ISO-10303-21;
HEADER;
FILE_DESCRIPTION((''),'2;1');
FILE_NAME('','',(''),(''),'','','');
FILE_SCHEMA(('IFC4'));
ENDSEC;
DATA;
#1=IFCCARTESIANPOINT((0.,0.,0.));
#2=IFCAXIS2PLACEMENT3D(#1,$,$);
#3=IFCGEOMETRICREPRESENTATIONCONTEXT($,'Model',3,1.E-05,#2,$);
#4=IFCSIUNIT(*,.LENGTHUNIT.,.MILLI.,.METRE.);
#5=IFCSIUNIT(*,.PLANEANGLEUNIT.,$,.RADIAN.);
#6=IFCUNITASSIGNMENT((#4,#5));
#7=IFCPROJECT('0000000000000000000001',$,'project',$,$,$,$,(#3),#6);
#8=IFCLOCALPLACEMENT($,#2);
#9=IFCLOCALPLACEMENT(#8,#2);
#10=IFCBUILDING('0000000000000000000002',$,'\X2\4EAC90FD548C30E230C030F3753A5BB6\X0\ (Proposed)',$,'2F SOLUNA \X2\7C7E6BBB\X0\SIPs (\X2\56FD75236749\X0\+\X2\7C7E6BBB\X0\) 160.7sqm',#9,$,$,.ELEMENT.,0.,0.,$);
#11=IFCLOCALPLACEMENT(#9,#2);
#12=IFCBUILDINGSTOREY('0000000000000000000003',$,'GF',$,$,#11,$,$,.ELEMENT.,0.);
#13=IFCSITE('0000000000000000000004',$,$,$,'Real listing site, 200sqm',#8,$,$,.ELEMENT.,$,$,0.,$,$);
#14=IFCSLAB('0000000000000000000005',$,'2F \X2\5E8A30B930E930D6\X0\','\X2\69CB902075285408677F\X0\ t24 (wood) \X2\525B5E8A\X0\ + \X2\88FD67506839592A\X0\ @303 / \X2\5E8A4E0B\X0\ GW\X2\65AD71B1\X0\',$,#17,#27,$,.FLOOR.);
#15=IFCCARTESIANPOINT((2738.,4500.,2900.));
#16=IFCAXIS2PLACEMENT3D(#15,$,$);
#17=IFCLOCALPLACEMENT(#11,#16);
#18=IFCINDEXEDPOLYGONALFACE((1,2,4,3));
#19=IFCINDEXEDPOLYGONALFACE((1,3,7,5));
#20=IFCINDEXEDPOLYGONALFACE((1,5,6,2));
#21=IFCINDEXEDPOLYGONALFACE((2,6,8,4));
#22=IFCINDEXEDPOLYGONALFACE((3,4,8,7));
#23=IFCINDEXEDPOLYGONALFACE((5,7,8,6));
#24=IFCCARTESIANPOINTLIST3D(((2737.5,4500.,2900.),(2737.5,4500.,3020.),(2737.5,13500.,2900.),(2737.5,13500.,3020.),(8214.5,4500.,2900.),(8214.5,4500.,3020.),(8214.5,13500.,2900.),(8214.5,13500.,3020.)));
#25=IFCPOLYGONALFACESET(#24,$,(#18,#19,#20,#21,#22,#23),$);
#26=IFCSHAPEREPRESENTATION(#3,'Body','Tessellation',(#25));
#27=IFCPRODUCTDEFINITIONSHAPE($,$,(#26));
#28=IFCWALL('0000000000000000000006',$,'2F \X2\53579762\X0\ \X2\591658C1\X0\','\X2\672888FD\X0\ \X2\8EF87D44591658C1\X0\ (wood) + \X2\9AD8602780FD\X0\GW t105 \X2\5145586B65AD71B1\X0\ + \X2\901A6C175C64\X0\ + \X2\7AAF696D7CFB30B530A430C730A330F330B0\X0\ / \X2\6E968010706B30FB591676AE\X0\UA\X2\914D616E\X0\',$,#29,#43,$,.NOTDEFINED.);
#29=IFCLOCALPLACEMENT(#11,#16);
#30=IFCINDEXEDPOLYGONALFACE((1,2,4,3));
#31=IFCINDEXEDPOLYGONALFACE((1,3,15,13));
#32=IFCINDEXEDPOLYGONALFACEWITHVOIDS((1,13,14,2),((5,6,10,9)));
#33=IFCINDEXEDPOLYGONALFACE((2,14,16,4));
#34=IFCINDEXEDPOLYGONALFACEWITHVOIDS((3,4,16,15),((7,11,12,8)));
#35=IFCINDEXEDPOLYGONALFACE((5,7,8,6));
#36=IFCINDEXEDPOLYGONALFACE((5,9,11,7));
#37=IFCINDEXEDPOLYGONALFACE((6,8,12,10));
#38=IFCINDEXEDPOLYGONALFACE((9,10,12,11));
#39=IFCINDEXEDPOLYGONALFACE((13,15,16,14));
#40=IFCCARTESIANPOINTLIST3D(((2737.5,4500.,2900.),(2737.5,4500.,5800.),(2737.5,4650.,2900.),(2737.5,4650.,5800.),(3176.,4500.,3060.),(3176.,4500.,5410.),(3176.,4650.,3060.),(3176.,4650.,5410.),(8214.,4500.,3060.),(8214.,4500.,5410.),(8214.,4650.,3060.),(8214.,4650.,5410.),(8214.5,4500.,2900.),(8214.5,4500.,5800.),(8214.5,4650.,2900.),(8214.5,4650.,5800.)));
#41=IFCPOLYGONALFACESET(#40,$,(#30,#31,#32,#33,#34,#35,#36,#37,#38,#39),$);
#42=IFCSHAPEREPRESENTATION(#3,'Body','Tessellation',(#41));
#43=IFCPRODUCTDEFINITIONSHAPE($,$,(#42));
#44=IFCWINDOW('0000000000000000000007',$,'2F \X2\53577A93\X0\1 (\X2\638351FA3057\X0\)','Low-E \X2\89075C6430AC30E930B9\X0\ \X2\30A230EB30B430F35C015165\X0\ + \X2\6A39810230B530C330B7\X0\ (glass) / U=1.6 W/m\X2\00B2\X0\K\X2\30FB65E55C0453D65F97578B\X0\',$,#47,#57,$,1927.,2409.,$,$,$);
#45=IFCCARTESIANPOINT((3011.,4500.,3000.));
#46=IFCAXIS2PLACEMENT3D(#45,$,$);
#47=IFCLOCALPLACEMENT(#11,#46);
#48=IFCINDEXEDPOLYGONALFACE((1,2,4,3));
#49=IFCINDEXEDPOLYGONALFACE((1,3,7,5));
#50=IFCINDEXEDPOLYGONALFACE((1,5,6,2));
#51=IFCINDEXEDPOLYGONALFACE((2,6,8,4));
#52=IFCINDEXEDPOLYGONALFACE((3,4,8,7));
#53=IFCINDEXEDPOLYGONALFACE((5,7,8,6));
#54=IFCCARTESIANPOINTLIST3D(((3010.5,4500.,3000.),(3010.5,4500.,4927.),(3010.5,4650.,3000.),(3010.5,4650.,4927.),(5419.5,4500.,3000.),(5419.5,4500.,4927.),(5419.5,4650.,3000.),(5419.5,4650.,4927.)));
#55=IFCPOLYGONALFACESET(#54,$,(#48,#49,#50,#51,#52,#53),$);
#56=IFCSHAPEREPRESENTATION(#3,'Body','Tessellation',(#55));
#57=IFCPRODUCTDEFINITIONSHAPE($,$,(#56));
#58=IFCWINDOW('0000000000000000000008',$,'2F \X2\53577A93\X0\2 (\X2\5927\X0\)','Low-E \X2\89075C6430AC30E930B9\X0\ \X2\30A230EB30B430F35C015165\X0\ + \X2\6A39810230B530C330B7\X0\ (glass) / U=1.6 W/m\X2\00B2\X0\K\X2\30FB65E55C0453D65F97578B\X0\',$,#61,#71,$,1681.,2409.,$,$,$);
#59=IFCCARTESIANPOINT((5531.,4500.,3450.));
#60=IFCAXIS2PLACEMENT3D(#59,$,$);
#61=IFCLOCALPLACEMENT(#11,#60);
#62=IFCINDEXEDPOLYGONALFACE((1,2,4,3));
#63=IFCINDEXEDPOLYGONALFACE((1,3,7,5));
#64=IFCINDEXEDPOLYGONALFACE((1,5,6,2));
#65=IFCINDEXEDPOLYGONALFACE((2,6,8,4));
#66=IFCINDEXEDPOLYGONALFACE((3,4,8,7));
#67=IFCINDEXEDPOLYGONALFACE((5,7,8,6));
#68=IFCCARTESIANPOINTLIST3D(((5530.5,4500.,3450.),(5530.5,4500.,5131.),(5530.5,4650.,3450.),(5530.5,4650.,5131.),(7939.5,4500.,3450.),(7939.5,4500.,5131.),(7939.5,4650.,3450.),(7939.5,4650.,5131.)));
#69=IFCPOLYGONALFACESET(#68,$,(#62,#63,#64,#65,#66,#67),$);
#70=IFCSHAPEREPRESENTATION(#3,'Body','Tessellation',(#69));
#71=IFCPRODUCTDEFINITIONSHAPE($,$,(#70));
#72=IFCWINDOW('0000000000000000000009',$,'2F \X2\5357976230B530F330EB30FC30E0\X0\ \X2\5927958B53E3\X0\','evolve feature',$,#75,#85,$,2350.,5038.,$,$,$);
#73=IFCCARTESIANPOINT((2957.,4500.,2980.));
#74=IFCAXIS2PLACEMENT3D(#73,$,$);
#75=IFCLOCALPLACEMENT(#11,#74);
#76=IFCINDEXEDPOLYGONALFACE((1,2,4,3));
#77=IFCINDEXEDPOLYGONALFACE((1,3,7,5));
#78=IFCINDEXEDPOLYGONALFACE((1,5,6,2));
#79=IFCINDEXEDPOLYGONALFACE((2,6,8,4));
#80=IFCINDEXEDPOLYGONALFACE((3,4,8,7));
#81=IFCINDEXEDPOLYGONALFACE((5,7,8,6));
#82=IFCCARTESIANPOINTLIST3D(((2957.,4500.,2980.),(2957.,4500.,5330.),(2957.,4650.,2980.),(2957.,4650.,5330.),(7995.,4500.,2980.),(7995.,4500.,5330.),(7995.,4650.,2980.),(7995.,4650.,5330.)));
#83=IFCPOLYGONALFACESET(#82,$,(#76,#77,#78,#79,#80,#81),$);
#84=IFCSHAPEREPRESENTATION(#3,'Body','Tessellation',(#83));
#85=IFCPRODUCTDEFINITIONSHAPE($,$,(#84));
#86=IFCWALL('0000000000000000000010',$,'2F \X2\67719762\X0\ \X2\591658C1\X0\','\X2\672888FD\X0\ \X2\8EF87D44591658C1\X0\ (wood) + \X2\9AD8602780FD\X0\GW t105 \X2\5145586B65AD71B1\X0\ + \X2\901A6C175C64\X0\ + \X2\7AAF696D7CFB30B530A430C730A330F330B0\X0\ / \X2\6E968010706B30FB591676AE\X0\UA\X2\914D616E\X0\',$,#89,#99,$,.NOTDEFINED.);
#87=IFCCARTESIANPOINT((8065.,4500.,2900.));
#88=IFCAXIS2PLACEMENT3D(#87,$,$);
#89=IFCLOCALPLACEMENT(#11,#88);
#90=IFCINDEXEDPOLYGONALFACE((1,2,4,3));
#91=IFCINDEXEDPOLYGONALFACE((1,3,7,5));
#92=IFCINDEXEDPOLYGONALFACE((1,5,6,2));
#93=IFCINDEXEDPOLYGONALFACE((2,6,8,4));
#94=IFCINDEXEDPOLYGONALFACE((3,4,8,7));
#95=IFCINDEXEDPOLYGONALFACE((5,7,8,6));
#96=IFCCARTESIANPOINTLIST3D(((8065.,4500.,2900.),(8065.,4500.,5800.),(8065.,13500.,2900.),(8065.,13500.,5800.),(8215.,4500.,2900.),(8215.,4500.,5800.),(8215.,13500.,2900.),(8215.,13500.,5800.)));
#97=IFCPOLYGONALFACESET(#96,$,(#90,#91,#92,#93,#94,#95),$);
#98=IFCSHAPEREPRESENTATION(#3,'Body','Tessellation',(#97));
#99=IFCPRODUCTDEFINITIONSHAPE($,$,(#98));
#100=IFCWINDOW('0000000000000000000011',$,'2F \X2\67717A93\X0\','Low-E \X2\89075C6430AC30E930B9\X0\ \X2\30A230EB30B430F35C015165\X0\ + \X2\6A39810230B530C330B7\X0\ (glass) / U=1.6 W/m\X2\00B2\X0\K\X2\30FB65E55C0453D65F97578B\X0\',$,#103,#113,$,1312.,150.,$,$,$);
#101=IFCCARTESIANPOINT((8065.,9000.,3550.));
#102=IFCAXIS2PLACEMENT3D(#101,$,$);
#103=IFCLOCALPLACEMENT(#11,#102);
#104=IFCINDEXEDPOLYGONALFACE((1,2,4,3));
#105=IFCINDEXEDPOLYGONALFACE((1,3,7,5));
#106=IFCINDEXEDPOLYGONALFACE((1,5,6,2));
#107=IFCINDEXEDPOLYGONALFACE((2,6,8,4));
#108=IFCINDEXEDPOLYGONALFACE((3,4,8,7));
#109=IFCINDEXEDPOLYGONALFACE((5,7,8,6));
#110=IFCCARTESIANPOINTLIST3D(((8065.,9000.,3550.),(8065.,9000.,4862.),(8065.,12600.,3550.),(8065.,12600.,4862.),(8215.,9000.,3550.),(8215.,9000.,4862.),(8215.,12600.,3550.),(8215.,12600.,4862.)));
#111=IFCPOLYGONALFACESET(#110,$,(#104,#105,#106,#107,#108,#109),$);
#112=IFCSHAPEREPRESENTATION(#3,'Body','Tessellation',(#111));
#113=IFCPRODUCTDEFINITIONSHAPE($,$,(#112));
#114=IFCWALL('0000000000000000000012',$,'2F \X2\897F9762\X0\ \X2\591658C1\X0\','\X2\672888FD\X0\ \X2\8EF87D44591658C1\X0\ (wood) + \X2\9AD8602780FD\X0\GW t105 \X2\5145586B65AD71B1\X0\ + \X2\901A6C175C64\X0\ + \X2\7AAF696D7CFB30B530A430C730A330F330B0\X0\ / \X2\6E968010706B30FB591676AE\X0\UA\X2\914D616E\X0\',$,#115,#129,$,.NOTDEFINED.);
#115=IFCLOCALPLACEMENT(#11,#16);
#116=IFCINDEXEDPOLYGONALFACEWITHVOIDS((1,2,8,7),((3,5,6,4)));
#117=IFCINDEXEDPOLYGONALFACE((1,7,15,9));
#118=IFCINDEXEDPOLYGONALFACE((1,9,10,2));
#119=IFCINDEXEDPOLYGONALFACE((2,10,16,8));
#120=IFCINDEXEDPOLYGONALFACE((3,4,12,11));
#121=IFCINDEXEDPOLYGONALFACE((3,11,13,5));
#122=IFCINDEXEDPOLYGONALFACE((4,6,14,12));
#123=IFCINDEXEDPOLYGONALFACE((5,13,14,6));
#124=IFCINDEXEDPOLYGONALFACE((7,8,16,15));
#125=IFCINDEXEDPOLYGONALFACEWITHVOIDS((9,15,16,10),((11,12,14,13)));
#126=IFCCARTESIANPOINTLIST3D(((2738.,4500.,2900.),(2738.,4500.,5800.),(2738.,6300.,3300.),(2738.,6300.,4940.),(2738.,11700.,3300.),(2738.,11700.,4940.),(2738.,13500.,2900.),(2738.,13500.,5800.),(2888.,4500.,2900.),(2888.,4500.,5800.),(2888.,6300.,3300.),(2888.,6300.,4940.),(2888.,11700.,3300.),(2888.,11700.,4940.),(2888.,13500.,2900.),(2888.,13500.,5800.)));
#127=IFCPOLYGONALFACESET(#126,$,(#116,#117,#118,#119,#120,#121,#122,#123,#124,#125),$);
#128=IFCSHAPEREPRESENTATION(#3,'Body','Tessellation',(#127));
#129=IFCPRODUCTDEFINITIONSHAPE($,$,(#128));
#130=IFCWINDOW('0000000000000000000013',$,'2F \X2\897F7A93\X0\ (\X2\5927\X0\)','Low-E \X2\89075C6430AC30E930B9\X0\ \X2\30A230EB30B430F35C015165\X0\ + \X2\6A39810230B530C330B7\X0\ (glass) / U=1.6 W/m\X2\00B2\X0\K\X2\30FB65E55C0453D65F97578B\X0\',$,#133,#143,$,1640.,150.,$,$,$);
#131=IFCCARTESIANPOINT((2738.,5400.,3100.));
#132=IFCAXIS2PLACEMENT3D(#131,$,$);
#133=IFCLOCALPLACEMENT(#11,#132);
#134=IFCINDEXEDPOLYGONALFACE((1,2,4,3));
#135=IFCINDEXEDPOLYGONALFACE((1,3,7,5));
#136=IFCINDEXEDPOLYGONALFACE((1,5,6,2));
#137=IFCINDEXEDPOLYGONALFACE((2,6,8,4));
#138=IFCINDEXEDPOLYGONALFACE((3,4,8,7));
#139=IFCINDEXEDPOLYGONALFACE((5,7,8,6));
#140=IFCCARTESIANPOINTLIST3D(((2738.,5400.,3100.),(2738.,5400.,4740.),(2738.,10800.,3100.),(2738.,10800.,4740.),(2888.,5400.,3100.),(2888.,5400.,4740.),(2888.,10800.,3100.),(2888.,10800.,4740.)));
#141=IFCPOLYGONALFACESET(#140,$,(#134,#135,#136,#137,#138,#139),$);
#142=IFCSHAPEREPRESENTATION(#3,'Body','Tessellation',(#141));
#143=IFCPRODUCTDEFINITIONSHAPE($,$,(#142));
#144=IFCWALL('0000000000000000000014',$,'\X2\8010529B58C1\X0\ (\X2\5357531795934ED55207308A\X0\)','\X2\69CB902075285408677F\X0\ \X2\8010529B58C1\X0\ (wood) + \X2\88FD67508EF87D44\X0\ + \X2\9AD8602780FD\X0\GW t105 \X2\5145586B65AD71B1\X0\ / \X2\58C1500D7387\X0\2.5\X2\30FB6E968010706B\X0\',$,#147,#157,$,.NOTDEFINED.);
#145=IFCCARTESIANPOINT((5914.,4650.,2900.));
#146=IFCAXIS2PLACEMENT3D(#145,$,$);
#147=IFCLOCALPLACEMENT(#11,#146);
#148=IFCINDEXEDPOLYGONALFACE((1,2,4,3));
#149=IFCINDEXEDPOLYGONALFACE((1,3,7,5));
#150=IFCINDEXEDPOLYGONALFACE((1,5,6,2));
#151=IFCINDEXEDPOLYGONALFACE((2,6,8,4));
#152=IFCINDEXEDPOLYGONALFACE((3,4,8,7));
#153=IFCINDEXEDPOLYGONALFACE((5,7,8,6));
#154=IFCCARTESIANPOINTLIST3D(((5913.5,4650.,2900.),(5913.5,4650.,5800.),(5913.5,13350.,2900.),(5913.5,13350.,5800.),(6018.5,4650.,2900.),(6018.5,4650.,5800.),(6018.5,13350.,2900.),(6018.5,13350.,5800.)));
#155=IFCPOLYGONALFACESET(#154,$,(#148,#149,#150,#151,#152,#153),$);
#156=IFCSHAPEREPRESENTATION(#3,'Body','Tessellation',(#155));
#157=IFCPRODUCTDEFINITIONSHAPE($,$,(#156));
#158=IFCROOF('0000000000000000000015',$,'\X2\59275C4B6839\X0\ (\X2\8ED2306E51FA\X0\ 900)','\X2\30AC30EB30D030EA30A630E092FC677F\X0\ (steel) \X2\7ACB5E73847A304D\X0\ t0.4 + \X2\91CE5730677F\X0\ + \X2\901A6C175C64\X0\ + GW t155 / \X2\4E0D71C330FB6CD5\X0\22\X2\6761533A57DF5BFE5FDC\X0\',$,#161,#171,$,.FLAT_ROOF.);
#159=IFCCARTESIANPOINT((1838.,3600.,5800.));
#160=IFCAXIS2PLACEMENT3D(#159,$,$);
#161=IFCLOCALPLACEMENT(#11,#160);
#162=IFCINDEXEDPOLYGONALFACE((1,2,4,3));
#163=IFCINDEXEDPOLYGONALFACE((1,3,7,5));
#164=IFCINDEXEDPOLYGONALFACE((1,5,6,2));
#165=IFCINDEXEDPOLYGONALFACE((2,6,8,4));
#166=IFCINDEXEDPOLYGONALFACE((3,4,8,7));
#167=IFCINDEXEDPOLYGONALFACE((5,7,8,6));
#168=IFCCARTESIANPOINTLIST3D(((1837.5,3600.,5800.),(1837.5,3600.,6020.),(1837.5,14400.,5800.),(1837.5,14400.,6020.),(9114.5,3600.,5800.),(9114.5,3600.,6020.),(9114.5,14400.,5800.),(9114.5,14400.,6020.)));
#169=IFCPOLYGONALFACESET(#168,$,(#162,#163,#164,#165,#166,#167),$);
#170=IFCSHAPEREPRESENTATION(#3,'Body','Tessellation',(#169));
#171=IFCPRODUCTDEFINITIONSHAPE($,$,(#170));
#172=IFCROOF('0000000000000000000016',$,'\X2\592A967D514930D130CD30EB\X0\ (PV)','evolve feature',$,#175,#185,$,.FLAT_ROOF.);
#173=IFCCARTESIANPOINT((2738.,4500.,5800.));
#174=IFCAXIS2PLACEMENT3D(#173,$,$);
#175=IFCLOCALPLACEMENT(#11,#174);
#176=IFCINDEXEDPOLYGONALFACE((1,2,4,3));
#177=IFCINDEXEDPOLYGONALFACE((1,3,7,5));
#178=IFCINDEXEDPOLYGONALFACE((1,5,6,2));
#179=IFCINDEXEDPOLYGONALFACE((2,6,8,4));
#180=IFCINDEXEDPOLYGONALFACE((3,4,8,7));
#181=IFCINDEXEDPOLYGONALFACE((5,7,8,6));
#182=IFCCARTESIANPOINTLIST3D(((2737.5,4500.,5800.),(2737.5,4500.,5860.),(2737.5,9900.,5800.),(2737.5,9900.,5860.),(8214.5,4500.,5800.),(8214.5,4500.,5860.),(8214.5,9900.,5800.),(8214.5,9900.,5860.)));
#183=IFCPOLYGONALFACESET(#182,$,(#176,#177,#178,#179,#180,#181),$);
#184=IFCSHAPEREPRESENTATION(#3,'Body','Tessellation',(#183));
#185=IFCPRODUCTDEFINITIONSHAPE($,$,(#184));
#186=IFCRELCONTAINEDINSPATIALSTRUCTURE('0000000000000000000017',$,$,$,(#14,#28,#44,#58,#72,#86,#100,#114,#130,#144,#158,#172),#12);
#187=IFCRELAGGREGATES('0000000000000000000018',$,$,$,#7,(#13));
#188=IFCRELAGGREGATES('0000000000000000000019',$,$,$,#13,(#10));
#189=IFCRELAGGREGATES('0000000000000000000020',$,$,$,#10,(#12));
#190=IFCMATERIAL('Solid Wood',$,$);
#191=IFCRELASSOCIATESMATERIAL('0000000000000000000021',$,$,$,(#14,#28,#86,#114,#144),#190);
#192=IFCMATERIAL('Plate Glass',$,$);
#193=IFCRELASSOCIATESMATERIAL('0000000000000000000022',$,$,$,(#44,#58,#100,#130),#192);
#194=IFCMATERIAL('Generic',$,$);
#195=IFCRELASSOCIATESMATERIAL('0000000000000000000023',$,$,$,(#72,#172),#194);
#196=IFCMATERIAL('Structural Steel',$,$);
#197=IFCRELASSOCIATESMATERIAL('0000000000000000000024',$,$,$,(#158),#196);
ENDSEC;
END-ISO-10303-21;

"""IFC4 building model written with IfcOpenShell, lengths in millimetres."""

from ifc_helpers import new_model, si_unit, frame, frame_2d, origin, place, context, project, spatial, rectangle, extrude, material, element, fill, save


model = new_model("IFC4")

# Units and contexts
model_context = context("Model", 3, precision=1e-05, world=origin())
ifc_project = project(units=[si_unit("LENGTHUNIT", "METRE", prefix="MILLI"), si_unit("PLANEANGLEUNIT", "RADIAN")], contexts=[model_context])

# Site, building, storey
site_placement = place(None, origin())
site = spatial("IfcSite", under=ifc_project, at=site_placement, ObjectType="Real listing site, 200sqm", CompositionType="ELEMENT", RefElevation=0.0)
building_placement = place(site_placement, origin())
building = spatial("IfcBuilding", under=site, at=building_placement, Name="京都和モダン町家 (Proposed)", ObjectType="2F SOLUNA 籾殻SIPs (国産杉+籾殻) 160.7sqm", CompositionType="ELEMENT", ElevationOfRefHeight=0.0, ElevationOfTerrain=0.0)
storey_placement = place(building_placement, origin())
storey = spatial("IfcBuildingStorey", under=building, at=storey_placement, Name="GF", CompositionType="ELEMENT", Elevation=0.0)

# Slab
ifc_material_1 = material(Name="Solid Wood")
slab_placement = place(storey_placement, frame((2738.0, 4500.0, 2900.0)))
element("IfcSlab", 1, at=slab_placement, inside=storey, material=ifc_material_1, Name="2F 床スラブ", Description="構造用合板 t24 (wood) 剛床 + 製材根太 @303 / 床下 GW断熱", PredefinedType="FLOOR", context=model_context, shape_type="SweptSolid", body=[
    extrude(rectangle(XDim=5477.0, YDim=9000.0, at=frame_2d((2738.0, 4500.0))), frame((2738.0, 4500.0, 2900.0)), (0.0, 0.0, 1.0), 120.0),
])

# Wall, openings, windows
wall_1_placement = place(storey_placement, frame((2738.0, 4500.0, 2900.0)))
wall_1 = element("IfcWall", 2, at=wall_1_placement, inside=storey, material=ifc_material_1, Name="2F 南面 外壁", Description="木製 軸組外壁 (wood) + 高性能GW t105 充填断熱 + 通気層 + 窯業系サイディング / 準耐火・外皮UA配慮", PredefinedType="NOTDEFINED", context=model_context, shape_type="SweptSolid", body=[
    extrude(rectangle(XDim=5477.0, YDim=150.0, at=frame_2d((2738.0, 75.0))), frame((2738.0, 4500.0, 2900.0)), (0.0, 0.0, 1.0), 2900.0),
])
opening_1_placement = place(storey_placement, frame((3011.0, 4500.0, 3000.0)))
opening_1 = element("IfcOpeningElement", 3, at=opening_1_placement, cuts=wall_1, PredefinedType="NOTDEFINED", context=model_context, shape_type="SweptSolid", body=[
    extrude(rectangle(XDim=2409.0, YDim=150.0, at=frame_2d((1204.0, 75.0))), frame((3011.0, 4500.0, 3000.0)), (0.0, 0.0, 1.0), 1927.0),
])
opening_2_placement = place(storey_placement, frame((5531.0, 4500.0, 3450.0)))
opening_2 = element("IfcOpeningElement", 4, at=opening_2_placement, cuts=wall_1, PredefinedType="NOTDEFINED", context=model_context, shape_type="SweptSolid", body=[
    extrude(rectangle(XDim=2409.0, YDim=150.0, at=frame_2d((1204.0, 75.0))), frame((5531.0, 4500.0, 3450.0)), (0.0, 0.0, 1.0), 1681.0),
])
opening_3_placement = place(storey_placement, frame((2957.0, 4500.0, 2980.0)))
opening_3 = element("IfcOpeningElement", 5, at=opening_3_placement, cuts=wall_1, PredefinedType="NOTDEFINED", context=model_context, shape_type="SweptSolid", body=[
    extrude(rectangle(XDim=5038.0, YDim=150.0, at=frame_2d((2519.0, 75.0))), frame((2957.0, 4500.0, 2980.0)), (0.0, 0.0, 1.0), 2350.0),
])
ifc_material_2 = material(Name="Plate Glass")
window_1_placement = place(storey_placement, frame((3011.0, 4500.0, 3000.0)))
window_1 = element("IfcWindow", 6, at=window_1_placement, inside=storey, material=ifc_material_2, Name="2F 南窓1 (掃出し)", Description="Low-E 複層ガラス アルゴン封入 + 樹脂サッシ (glass) / U=1.6 W/m²K・日射取得型", OverallHeight=1927.0, OverallWidth=2409.0, context=model_context, shape_type="SweptSolid", body=[
    extrude(rectangle(XDim=2409.0, YDim=150.0, at=frame_2d((1204.0, 75.0))), frame((3011.0, 4500.0, 3000.0)), (0.0, 0.0, 1.0), 1927.0),
])
fill(opening_1, window_1)
window_2_placement = place(storey_placement, frame((5531.0, 4500.0, 3450.0)))
window_2 = element("IfcWindow", 7, at=window_2_placement, inside=storey, material=ifc_material_2, Name="2F 南窓2 (大)", Description="Low-E 複層ガラス アルゴン封入 + 樹脂サッシ (glass) / U=1.6 W/m²K・日射取得型", OverallHeight=1681.0, OverallWidth=2409.0, context=model_context, shape_type="SweptSolid", body=[
    extrude(rectangle(XDim=2409.0, YDim=150.0, at=frame_2d((1204.0, 75.0))), frame((5531.0, 4500.0, 3450.0)), (0.0, 0.0, 1.0), 1681.0),
])
fill(opening_2, window_2)
ifc_material_3 = material(Name="Generic")
window_3_placement = place(storey_placement, frame((2957.0, 4500.0, 2980.0)))
window_3 = element("IfcWindow", 8, at=window_3_placement, inside=storey, material=ifc_material_3, Name="2F 南面サンルーム 大開口", Description="evolve feature", OverallHeight=2350.0, OverallWidth=5038.0, context=model_context, shape_type="SweptSolid", body=[
    extrude(rectangle(XDim=5038.0, YDim=150.0, at=frame_2d((2519.0, 75.0))), frame((2957.0, 4500.0, 2980.0)), (0.0, 0.0, 1.0), 2350.0),
])
fill(opening_3, window_3)

# Walls, openings, windows
wall_2_placement = place(storey_placement, frame((8065.0, 4500.0, 2900.0)))
wall_2 = element("IfcWall", 9, at=wall_2_placement, inside=storey, material=ifc_material_1, Name="2F 東面 外壁", Description="木製 軸組外壁 (wood) + 高性能GW t105 充填断熱 + 通気層 + 窯業系サイディング / 準耐火・外皮UA配慮", PredefinedType="NOTDEFINED", context=model_context, shape_type="SweptSolid", body=[
    extrude(rectangle(XDim=150.0, YDim=9000.0, at=frame_2d((75.0, 4500.0))), frame((8065.0, 4500.0, 2900.0)), (0.0, 0.0, 1.0), 2900.0),
])
opening_4_placement = place(storey_placement, frame((8065.0, 9000.0, 3550.0)))
opening_4 = element("IfcOpeningElement", 10, at=opening_4_placement, cuts=wall_2, PredefinedType="NOTDEFINED", context=model_context, shape_type="SweptSolid", body=[
    extrude(rectangle(XDim=150.0, YDim=3600.0, at=frame_2d((75.0, 1800.0))), frame((8065.0, 9000.0, 3550.0)), (0.0, 0.0, 1.0), 1312.0),
])
window_4_placement = place(storey_placement, frame((8065.0, 9000.0, 3550.0)))
window_4 = element("IfcWindow", 11, at=window_4_placement, inside=storey, material=ifc_material_2, Name="2F 東窓", Description="Low-E 複層ガラス アルゴン封入 + 樹脂サッシ (glass) / U=1.6 W/m²K・日射取得型", OverallHeight=1312.0, OverallWidth=150.0, context=model_context, shape_type="SweptSolid", body=[
    extrude(rectangle(XDim=150.0, YDim=3600.0, at=frame_2d((75.0, 1800.0))), frame((8065.0, 9000.0, 3550.0)), (0.0, 0.0, 1.0), 1312.0),
])
fill(opening_4, window_4)
wall_3_placement = place(storey_placement, frame((2738.0, 4500.0, 2900.0)))
wall_3 = element("IfcWall", 12, at=wall_3_placement, inside=storey, material=ifc_material_1, Name="2F 西面 外壁", Description="木製 軸組外壁 (wood) + 高性能GW t105 充填断熱 + 通気層 + 窯業系サイディング / 準耐火・外皮UA配慮", PredefinedType="NOTDEFINED", context=model_context, shape_type="SweptSolid", body=[
    extrude(rectangle(XDim=150.0, YDim=9000.0, at=frame_2d((75.0, 4500.0))), frame((2738.0, 4500.0, 2900.0)), (0.0, 0.0, 1.0), 2900.0),
])
opening_5_placement = place(storey_placement, frame((2738.0, 5400.0, 3100.0)))
opening_5 = element("IfcOpeningElement", 13, at=opening_5_placement, cuts=wall_3, PredefinedType="NOTDEFINED", context=model_context, shape_type="SweptSolid", body=[
    extrude(rectangle(XDim=150.0, YDim=5400.0, at=frame_2d((75.0, 2700.0))), frame((2738.0, 5400.0, 3100.0)), (0.0, 0.0, 1.0), 1640.0),
])
window_5_placement = place(storey_placement, frame((2738.0, 5400.0, 3100.0)))
window_5 = element("IfcWindow", 14, at=window_5_placement, inside=storey, material=ifc_material_2, Name="2F 西窓 (大)", Description="Low-E 複層ガラス アルゴン封入 + 樹脂サッシ (glass) / U=1.6 W/m²K・日射取得型", OverallHeight=1640.0, OverallWidth=150.0, context=model_context, shape_type="SweptSolid", body=[
    extrude(rectangle(XDim=150.0, YDim=5400.0, at=frame_2d((75.0, 2700.0))), frame((2738.0, 5400.0, 3100.0)), (0.0, 0.0, 1.0), 1640.0),
])
fill(opening_5, window_5)

# Wall
wall_4_placement = place(storey_placement, frame((5914.0, 4650.0, 2900.0)))
element("IfcWall", 15, at=wall_4_placement, inside=storey, material=ifc_material_1, Name="耐力壁 (南北間仕切り)", Description="構造用合板 耐力壁 (wood) + 製材軸組 + 高性能GW t105 充填断熱 / 壁倍率2.5・準耐火", PredefinedType="NOTDEFINED", context=model_context, shape_type="SweptSolid", body=[
    extrude(rectangle(XDim=105.0, YDim=8700.0, at=frame_2d((52.0, 4350.0))), frame((5914.0, 4650.0, 2900.0)), (0.0, 0.0, 1.0), 2900.0),
])

# Roofs
ifc_material_4 = material(Name="Structural Steel")
roof_1_placement = place(storey_placement, frame((1838.0, 3600.0, 5800.0)))
element("IfcRoof", 16, at=roof_1_placement, inside=storey, material=ifc_material_4, Name="大屋根 (軒の出 900)", Description="ガルバリウム鋼板 (steel) 立平葺き t0.4 + 野地板 + 通気層 + GW t155 / 不燃・法22条区域対応", PredefinedType="FLAT_ROOF", context=model_context, shape_type="SweptSolid", body=[
    extrude(rectangle(XDim=7277.0, YDim=10800.0, at=frame_2d((3638.0, 5400.0))), frame((1838.0, 3600.0, 5800.0)), (0.0, 0.0, 1.0), 220.0),
])
roof_2_placement = place(storey_placement, frame((2738.0, 4500.0, 5800.0)))
element("IfcRoof", 17, at=roof_2_placement, inside=storey, material=ifc_material_3, Name="太陽光パネル (PV)", Description="evolve feature", PredefinedType="FLAT_ROOF", context=model_context, shape_type="SweptSolid", body=[
    extrude(rectangle(XDim=5477.0, YDim=5400.0, at=frame_2d((2738.0, 2700.0))), frame((2738.0, 4500.0, 5800.0)), (0.0, 0.0, 1.0), 60.0),
])

save(model, "model.ifc")
